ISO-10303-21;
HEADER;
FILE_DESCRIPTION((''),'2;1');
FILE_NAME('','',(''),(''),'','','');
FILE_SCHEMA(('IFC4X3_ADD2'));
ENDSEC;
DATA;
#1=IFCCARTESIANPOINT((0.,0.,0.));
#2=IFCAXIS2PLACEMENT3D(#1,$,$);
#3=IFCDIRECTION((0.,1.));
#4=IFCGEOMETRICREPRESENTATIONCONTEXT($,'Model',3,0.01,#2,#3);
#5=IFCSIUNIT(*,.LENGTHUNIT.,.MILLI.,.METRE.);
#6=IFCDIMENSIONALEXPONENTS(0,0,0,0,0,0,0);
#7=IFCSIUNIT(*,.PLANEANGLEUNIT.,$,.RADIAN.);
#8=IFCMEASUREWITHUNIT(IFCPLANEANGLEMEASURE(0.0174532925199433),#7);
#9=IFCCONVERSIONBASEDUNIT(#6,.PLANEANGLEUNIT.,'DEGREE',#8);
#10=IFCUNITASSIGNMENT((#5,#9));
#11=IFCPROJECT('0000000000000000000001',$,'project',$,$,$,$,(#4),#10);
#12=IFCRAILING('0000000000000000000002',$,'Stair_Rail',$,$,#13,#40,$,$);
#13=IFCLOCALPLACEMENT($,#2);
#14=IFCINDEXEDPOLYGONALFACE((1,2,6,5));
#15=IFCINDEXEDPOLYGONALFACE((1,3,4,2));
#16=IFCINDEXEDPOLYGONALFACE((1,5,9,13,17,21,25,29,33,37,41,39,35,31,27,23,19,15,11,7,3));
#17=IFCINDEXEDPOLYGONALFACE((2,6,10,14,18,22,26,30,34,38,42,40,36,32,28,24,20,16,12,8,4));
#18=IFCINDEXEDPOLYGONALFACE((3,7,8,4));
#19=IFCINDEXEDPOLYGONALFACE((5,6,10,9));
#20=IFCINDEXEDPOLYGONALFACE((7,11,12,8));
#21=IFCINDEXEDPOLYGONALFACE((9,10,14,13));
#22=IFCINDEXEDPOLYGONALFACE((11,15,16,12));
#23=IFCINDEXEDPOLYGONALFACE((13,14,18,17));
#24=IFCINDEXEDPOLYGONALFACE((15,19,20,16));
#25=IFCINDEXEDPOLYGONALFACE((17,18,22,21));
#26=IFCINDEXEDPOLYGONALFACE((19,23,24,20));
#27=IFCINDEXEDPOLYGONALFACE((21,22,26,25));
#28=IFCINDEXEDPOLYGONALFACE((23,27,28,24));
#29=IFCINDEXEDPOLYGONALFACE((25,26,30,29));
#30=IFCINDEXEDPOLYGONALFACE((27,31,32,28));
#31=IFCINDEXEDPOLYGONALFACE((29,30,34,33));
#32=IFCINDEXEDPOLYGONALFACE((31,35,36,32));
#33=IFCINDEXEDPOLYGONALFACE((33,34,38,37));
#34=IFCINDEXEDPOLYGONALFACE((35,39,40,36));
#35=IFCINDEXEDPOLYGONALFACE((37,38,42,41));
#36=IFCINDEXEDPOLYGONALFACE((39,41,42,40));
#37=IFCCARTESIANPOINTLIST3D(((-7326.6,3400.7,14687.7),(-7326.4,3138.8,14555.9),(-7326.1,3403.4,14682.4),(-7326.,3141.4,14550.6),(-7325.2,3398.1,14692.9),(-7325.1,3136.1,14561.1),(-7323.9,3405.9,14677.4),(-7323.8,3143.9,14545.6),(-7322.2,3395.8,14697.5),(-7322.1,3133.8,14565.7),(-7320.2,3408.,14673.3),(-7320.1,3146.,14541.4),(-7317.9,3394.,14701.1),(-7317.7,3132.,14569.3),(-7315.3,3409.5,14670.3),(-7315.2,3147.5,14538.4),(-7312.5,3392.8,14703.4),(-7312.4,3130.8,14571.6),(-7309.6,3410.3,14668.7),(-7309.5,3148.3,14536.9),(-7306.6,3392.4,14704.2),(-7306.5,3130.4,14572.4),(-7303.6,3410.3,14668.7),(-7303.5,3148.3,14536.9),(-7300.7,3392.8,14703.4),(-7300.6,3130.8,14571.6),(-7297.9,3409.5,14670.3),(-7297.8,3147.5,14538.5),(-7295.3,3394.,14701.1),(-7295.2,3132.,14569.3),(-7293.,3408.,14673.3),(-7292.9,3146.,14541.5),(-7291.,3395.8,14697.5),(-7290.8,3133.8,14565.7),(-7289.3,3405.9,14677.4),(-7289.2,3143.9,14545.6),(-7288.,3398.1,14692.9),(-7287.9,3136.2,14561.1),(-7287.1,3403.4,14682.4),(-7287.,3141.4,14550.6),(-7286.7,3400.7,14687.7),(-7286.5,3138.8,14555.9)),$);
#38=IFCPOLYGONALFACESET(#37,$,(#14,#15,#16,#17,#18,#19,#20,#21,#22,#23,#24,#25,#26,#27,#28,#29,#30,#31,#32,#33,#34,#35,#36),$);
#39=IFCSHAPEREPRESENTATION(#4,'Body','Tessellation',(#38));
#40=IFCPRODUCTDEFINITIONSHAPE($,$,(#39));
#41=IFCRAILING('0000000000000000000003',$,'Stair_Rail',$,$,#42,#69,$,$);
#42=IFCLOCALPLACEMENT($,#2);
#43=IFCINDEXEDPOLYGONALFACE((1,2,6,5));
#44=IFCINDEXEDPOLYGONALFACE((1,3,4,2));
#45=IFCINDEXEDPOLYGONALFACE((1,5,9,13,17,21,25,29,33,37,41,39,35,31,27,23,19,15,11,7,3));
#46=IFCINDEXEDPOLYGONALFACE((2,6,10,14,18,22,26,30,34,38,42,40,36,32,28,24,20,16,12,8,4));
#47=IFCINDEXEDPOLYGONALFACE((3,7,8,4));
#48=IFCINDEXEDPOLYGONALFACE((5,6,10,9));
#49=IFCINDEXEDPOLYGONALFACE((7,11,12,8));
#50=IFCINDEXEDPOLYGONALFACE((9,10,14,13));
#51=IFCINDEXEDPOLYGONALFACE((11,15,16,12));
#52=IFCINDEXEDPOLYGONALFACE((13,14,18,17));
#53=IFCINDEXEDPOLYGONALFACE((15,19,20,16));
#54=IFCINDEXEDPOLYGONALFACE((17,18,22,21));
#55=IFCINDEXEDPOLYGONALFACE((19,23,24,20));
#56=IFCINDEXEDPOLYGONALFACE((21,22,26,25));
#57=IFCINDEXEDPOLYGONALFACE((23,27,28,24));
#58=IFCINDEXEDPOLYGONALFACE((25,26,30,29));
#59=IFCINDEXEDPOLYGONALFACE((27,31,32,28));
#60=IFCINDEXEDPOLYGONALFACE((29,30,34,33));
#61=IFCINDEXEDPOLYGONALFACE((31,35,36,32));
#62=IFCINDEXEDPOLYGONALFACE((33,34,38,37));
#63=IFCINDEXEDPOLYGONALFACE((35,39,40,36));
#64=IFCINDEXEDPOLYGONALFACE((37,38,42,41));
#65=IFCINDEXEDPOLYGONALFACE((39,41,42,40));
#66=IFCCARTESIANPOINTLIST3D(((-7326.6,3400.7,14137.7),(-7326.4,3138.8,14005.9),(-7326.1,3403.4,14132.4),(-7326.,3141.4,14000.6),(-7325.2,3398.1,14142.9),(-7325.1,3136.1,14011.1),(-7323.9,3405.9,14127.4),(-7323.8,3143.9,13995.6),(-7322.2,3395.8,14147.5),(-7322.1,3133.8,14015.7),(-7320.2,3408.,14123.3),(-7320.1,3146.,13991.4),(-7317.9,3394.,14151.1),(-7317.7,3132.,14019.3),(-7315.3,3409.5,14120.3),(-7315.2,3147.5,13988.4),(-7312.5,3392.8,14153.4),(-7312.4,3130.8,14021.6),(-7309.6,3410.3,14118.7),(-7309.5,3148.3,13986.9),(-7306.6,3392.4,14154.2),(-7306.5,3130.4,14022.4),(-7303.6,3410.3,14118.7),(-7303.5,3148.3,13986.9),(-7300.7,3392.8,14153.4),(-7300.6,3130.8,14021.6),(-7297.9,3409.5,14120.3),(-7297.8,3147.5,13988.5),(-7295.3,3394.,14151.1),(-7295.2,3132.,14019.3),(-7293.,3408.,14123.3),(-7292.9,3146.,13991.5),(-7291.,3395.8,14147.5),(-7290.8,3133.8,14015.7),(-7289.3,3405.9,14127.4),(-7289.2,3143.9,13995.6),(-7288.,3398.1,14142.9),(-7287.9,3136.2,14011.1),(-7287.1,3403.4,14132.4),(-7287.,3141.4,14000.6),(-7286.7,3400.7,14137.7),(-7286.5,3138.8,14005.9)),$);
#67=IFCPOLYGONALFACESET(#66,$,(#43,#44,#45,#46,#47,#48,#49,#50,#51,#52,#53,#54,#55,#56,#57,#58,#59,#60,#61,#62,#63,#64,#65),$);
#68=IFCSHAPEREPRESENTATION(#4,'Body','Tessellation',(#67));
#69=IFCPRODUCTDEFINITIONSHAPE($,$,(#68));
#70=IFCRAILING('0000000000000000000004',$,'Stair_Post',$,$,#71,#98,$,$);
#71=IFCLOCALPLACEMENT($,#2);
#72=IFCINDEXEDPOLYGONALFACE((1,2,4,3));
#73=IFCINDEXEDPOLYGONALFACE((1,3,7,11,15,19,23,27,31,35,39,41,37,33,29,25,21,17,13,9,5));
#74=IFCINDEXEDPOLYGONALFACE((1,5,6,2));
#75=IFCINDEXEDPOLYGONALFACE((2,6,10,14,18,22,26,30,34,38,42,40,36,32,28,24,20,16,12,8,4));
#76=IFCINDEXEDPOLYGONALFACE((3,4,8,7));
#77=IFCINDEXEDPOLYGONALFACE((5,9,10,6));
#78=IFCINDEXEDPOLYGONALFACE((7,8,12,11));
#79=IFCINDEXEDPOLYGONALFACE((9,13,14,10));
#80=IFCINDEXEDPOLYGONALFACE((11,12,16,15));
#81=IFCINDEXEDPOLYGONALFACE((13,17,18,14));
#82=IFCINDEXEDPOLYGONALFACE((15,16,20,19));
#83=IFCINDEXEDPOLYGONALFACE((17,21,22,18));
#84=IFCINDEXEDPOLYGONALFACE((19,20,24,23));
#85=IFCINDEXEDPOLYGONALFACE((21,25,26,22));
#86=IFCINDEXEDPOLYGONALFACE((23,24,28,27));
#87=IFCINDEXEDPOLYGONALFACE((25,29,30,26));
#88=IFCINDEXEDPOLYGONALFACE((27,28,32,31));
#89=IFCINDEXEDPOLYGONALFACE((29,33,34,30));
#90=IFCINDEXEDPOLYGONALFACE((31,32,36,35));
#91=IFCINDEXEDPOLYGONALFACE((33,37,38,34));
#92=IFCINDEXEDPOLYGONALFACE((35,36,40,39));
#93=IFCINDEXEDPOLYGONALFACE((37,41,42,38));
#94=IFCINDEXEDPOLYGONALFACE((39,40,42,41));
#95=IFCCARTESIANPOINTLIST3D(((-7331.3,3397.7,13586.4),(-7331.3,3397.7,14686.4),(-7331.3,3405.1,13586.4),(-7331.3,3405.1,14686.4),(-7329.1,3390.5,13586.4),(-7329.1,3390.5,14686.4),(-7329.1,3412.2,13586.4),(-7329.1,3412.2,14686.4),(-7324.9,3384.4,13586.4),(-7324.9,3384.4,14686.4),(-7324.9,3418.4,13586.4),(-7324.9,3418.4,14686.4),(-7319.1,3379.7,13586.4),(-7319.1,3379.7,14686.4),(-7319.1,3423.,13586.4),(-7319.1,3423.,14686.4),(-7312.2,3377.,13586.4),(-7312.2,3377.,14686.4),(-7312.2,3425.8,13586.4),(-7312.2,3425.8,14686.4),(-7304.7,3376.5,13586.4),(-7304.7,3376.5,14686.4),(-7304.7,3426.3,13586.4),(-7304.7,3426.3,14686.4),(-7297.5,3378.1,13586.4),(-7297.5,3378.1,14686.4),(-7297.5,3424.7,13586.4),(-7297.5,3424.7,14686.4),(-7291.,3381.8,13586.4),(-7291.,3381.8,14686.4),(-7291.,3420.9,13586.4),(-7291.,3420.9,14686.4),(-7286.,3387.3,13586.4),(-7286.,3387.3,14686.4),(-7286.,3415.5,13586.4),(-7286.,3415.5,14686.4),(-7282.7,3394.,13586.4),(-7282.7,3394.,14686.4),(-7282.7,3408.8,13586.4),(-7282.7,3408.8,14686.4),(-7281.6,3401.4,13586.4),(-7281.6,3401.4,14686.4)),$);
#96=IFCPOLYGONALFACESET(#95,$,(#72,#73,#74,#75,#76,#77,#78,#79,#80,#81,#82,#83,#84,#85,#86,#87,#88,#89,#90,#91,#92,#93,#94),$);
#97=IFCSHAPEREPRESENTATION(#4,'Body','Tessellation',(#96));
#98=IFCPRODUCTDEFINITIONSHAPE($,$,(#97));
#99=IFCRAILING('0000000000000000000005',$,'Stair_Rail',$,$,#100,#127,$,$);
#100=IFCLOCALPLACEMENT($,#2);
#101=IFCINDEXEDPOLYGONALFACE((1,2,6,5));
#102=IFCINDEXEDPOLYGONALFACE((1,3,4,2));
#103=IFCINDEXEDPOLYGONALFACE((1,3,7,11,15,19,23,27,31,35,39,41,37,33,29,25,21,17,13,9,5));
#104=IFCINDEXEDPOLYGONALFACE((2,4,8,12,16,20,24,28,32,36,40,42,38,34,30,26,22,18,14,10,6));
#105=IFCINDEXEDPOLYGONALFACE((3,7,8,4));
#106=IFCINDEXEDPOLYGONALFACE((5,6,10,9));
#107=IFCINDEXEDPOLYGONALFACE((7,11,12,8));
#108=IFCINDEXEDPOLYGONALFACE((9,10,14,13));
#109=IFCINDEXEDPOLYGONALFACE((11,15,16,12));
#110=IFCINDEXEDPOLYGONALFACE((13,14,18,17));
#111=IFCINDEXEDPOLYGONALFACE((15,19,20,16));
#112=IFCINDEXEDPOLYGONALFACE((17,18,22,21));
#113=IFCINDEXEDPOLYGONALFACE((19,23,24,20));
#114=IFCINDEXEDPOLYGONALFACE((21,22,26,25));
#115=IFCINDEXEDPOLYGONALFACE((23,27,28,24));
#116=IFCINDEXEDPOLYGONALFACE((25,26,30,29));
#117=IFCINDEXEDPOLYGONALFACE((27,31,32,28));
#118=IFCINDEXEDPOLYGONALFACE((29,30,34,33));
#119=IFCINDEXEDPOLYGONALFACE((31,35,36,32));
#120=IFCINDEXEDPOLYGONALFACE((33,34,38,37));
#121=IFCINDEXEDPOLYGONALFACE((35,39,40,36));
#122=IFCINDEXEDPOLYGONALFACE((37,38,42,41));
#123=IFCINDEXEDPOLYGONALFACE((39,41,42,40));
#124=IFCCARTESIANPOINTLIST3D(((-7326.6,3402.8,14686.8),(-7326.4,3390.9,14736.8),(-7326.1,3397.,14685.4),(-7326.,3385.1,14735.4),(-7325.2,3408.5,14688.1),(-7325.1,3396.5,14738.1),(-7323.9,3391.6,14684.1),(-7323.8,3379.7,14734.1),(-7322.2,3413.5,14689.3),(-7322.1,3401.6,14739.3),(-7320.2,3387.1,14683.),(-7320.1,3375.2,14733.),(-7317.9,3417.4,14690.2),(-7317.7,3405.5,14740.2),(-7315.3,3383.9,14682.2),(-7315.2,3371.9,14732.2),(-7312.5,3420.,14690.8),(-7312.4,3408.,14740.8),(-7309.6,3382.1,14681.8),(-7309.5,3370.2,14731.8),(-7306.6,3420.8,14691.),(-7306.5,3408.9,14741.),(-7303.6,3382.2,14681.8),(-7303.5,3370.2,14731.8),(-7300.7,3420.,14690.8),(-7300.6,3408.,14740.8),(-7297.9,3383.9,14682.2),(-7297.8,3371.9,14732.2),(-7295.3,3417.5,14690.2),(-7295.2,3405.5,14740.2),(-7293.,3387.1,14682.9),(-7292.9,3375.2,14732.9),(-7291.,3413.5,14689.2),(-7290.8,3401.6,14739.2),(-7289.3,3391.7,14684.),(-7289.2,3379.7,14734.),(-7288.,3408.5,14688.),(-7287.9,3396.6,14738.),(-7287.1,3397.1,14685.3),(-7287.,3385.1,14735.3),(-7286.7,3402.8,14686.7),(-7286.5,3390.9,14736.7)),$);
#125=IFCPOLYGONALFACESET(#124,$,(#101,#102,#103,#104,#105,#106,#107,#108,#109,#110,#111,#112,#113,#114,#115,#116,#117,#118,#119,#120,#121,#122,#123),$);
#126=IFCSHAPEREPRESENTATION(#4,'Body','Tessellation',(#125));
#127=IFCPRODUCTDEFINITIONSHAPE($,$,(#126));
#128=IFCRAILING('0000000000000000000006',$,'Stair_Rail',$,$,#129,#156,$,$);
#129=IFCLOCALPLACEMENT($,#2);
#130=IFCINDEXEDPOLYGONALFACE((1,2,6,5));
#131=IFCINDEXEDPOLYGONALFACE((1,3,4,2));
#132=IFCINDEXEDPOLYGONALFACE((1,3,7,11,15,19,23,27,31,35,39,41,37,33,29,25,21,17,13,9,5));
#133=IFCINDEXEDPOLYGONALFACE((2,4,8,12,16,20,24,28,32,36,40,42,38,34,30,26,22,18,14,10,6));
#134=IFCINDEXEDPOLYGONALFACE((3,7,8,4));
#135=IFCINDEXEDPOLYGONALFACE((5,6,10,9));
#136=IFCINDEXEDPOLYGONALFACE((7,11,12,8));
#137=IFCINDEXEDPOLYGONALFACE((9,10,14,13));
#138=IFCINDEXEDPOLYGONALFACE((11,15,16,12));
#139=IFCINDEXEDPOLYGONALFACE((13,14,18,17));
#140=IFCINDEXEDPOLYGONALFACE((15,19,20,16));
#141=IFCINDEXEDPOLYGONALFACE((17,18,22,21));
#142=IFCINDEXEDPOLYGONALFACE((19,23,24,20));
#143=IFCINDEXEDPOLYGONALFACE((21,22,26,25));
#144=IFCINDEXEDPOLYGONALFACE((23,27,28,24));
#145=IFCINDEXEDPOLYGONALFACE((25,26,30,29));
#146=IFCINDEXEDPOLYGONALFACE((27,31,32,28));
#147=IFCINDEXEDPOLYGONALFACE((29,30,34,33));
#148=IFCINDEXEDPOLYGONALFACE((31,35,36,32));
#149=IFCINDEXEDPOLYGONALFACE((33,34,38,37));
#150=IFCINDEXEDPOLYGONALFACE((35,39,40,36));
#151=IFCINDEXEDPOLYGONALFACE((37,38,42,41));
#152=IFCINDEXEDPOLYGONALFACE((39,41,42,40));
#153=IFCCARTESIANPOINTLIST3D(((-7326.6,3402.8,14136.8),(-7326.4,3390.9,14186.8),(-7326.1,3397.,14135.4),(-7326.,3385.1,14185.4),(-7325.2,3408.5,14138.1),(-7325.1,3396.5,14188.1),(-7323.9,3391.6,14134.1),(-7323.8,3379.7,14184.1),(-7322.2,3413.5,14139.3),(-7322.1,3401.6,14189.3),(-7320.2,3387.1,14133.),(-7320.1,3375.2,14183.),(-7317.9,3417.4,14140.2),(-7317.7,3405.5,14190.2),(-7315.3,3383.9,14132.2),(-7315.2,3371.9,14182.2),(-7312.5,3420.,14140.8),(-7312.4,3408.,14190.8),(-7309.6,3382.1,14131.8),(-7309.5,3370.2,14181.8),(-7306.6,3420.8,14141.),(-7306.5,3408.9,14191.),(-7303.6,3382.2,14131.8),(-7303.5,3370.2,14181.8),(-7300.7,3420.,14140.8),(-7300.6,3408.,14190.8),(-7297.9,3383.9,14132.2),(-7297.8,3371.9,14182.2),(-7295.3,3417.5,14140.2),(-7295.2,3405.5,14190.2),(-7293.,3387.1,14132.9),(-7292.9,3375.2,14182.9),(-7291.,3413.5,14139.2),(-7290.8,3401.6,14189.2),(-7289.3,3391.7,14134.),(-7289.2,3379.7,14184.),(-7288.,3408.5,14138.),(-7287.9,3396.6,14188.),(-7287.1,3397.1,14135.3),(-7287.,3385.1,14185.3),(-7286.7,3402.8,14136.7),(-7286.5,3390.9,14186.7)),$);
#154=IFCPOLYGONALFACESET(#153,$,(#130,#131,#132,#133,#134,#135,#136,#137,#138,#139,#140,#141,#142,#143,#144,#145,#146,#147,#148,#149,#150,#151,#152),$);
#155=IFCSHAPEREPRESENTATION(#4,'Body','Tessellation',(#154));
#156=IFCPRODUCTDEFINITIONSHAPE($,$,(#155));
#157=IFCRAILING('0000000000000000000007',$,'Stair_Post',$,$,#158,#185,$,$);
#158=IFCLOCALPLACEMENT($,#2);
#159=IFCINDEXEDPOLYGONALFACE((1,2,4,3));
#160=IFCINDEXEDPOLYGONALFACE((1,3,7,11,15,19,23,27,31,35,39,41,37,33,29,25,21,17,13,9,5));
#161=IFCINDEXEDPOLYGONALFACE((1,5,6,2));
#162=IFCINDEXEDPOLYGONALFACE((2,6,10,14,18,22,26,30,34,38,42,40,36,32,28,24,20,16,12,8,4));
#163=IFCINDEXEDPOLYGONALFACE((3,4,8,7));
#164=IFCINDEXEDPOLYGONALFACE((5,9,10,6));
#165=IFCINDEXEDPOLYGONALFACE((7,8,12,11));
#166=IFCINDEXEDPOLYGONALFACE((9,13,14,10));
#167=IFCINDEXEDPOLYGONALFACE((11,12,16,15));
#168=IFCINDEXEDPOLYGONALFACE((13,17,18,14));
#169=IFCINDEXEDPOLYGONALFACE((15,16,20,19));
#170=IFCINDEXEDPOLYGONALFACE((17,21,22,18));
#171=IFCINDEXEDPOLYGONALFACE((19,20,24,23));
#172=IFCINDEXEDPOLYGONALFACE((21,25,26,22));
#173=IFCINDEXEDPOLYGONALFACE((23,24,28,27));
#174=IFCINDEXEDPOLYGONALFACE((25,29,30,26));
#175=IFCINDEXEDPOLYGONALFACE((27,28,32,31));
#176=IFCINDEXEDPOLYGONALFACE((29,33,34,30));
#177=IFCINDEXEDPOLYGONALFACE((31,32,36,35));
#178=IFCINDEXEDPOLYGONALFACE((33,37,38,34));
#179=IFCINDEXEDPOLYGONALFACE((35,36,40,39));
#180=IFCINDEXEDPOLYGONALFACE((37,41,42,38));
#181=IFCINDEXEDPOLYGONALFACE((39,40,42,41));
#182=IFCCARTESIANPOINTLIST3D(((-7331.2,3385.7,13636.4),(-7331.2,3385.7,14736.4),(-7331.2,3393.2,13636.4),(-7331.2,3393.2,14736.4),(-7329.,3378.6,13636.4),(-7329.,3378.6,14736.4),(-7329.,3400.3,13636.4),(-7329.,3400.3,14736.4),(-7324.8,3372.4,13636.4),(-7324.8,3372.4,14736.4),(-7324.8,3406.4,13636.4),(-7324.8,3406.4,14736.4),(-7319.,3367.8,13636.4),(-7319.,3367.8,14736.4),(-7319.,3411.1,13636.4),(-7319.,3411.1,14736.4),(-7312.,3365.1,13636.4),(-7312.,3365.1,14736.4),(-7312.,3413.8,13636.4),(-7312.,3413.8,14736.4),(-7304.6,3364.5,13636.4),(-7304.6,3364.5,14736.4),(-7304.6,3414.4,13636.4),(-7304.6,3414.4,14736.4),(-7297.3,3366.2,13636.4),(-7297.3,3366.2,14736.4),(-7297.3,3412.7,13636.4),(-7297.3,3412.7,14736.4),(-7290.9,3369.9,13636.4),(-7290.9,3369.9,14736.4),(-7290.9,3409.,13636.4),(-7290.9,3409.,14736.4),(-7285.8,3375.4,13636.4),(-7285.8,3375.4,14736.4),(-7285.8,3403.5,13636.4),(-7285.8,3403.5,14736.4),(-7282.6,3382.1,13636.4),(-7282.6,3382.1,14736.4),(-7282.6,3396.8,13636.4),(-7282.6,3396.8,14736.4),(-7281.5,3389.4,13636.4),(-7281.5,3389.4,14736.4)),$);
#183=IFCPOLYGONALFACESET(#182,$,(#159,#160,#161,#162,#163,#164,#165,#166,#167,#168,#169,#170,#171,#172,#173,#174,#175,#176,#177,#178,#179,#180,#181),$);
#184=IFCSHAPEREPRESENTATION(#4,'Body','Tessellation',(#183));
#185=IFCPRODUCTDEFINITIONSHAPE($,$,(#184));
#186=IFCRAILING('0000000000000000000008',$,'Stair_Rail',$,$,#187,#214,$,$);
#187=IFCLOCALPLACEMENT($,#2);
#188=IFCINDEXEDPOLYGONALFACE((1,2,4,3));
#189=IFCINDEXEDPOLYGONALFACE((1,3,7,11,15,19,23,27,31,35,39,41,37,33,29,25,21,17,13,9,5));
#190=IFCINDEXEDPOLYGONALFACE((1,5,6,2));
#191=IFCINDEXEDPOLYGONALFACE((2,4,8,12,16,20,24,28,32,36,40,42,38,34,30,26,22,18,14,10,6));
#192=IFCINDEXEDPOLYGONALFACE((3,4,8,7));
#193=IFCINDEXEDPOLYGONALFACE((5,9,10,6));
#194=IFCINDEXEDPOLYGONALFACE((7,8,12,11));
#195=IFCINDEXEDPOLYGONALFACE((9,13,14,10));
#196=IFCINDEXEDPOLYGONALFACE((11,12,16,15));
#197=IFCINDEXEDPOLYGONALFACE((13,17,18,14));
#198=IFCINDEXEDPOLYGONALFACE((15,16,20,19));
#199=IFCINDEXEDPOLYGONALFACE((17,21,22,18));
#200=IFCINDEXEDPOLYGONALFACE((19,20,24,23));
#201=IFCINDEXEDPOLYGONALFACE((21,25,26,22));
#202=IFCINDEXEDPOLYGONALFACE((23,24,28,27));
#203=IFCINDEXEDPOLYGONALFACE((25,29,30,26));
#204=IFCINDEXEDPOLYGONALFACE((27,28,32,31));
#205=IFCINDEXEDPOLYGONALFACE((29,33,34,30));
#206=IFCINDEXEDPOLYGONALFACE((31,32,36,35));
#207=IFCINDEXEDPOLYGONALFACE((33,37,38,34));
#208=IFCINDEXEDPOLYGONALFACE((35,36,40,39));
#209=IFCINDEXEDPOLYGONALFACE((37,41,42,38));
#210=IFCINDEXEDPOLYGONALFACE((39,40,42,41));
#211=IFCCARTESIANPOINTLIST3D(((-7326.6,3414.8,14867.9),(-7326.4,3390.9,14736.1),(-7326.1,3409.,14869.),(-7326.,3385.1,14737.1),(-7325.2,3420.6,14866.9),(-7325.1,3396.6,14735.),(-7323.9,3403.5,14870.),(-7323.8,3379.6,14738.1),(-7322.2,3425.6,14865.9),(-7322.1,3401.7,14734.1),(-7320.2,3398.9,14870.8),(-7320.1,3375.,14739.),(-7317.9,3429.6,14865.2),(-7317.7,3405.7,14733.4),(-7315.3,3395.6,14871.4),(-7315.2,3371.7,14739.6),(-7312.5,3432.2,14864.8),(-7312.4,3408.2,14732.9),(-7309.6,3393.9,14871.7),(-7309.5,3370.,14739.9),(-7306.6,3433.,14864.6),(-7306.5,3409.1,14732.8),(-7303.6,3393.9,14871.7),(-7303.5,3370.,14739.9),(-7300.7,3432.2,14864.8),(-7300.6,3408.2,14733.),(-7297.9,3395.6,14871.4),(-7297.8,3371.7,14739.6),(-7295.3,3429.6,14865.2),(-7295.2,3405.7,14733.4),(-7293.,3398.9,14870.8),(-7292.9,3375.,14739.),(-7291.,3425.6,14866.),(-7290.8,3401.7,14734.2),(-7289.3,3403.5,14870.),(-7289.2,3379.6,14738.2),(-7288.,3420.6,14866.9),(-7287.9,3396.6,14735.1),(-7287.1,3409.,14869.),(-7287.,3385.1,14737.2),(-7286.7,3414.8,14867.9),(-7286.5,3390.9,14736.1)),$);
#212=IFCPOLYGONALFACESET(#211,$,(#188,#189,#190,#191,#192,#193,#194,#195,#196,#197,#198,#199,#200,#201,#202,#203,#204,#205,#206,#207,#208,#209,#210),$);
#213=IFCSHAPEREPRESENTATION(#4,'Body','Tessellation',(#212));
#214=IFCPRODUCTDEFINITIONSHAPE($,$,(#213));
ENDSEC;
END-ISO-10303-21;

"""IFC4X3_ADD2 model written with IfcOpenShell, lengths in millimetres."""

from ifc_helpers import new_model, entity, si_unit, converted_unit, direction, frame, origin, context, project, circle, extrude, element, save


model = new_model("IFC4X3_ADD2")

# Units and contexts
model_context = context("Model", 3, precision=0.01, world=origin(), true_north=direction((0.0, 1.0)))
ifc_project = project(units=[si_unit("LENGTHUNIT", "METRE", prefix="MILLI"), converted_unit("PLANEANGLEUNIT", "DEGREE", entity("IfcPlaneAngleMeasure", 0.0174532925199433), si_unit("PLANEANGLEUNIT", "RADIAN"), dimensions=[0, 0, 0, 0, 0, 0, 0])], contexts=[model_context])

# Railings
element("IfcRailing", 1, Name="Stair_Rail", context=model_context, shape_type="SweptSolid", body=[
    entity("IfcSweptDiskSolid", entity("IfcPolyline", [entity("IfcCartesianPoint", [-7306.5, 3139.4, 14554.5]), entity("IfcCartesianPoint", [-7306.6, 3401.4, 14686.4])]), 20.0),
])
element("IfcRailing", 2, Name="Stair_Rail", context=model_context, shape_type="SweptSolid", body=[
    entity("IfcSweptDiskSolid", entity("IfcPolyline", [entity("IfcCartesianPoint", [-7306.5, 3139.4, 14004.5]), entity("IfcCartesianPoint", [-7306.6, 3401.4, 14136.4])]), 20.0),
])
element("IfcRailing", 3, Name="Stair_Post", context=model_context, shape_type="SweptSolid", body=[
    extrude(circle(Radius=25.0), frame((-7306.6, 3401.4, 13586.4)), (0.0, 0.0, 1.0), 1100.0),
])
element("IfcRailing", 4, Name="Stair_Rail", context=model_context, shape_type="SweptSolid", body=[
    entity("IfcSweptDiskSolid", entity("IfcPolyline", [entity("IfcCartesianPoint", [-7306.6, 3401.4, 14686.4]), entity("IfcCartesianPoint", [-7306.5, 3389.4, 14736.4])]), 20.0),
])
element("IfcRailing", 5, Name="Stair_Rail", context=model_context, shape_type="SweptSolid", body=[
    entity("IfcSweptDiskSolid", entity("IfcPolyline", [entity("IfcCartesianPoint", [-7306.6, 3401.4, 14136.4]), entity("IfcCartesianPoint", [-7306.5, 3389.4, 14186.4])]), 20.0),
])
element("IfcRailing", 6, Name="Stair_Post", context=model_context, shape_type="SweptSolid", body=[
    extrude(circle(Radius=25.0), frame((-7306.5, 3389.4, 13636.4)), (0.0, 0.0, 1.0), 1100.0),
])
element("IfcRailing", 7, Name="Stair_Rail", context=model_context, shape_type="SweptSolid", body=[
    entity("IfcSweptDiskSolid", entity("IfcPolyline", [entity("IfcCartesianPoint", [-7306.5, 3389.4, 14736.4]), entity("IfcCartesianPoint", [-7306.6, 3413.4, 14868.2])]), 20.0),
])

save(model, "model.ifc")
